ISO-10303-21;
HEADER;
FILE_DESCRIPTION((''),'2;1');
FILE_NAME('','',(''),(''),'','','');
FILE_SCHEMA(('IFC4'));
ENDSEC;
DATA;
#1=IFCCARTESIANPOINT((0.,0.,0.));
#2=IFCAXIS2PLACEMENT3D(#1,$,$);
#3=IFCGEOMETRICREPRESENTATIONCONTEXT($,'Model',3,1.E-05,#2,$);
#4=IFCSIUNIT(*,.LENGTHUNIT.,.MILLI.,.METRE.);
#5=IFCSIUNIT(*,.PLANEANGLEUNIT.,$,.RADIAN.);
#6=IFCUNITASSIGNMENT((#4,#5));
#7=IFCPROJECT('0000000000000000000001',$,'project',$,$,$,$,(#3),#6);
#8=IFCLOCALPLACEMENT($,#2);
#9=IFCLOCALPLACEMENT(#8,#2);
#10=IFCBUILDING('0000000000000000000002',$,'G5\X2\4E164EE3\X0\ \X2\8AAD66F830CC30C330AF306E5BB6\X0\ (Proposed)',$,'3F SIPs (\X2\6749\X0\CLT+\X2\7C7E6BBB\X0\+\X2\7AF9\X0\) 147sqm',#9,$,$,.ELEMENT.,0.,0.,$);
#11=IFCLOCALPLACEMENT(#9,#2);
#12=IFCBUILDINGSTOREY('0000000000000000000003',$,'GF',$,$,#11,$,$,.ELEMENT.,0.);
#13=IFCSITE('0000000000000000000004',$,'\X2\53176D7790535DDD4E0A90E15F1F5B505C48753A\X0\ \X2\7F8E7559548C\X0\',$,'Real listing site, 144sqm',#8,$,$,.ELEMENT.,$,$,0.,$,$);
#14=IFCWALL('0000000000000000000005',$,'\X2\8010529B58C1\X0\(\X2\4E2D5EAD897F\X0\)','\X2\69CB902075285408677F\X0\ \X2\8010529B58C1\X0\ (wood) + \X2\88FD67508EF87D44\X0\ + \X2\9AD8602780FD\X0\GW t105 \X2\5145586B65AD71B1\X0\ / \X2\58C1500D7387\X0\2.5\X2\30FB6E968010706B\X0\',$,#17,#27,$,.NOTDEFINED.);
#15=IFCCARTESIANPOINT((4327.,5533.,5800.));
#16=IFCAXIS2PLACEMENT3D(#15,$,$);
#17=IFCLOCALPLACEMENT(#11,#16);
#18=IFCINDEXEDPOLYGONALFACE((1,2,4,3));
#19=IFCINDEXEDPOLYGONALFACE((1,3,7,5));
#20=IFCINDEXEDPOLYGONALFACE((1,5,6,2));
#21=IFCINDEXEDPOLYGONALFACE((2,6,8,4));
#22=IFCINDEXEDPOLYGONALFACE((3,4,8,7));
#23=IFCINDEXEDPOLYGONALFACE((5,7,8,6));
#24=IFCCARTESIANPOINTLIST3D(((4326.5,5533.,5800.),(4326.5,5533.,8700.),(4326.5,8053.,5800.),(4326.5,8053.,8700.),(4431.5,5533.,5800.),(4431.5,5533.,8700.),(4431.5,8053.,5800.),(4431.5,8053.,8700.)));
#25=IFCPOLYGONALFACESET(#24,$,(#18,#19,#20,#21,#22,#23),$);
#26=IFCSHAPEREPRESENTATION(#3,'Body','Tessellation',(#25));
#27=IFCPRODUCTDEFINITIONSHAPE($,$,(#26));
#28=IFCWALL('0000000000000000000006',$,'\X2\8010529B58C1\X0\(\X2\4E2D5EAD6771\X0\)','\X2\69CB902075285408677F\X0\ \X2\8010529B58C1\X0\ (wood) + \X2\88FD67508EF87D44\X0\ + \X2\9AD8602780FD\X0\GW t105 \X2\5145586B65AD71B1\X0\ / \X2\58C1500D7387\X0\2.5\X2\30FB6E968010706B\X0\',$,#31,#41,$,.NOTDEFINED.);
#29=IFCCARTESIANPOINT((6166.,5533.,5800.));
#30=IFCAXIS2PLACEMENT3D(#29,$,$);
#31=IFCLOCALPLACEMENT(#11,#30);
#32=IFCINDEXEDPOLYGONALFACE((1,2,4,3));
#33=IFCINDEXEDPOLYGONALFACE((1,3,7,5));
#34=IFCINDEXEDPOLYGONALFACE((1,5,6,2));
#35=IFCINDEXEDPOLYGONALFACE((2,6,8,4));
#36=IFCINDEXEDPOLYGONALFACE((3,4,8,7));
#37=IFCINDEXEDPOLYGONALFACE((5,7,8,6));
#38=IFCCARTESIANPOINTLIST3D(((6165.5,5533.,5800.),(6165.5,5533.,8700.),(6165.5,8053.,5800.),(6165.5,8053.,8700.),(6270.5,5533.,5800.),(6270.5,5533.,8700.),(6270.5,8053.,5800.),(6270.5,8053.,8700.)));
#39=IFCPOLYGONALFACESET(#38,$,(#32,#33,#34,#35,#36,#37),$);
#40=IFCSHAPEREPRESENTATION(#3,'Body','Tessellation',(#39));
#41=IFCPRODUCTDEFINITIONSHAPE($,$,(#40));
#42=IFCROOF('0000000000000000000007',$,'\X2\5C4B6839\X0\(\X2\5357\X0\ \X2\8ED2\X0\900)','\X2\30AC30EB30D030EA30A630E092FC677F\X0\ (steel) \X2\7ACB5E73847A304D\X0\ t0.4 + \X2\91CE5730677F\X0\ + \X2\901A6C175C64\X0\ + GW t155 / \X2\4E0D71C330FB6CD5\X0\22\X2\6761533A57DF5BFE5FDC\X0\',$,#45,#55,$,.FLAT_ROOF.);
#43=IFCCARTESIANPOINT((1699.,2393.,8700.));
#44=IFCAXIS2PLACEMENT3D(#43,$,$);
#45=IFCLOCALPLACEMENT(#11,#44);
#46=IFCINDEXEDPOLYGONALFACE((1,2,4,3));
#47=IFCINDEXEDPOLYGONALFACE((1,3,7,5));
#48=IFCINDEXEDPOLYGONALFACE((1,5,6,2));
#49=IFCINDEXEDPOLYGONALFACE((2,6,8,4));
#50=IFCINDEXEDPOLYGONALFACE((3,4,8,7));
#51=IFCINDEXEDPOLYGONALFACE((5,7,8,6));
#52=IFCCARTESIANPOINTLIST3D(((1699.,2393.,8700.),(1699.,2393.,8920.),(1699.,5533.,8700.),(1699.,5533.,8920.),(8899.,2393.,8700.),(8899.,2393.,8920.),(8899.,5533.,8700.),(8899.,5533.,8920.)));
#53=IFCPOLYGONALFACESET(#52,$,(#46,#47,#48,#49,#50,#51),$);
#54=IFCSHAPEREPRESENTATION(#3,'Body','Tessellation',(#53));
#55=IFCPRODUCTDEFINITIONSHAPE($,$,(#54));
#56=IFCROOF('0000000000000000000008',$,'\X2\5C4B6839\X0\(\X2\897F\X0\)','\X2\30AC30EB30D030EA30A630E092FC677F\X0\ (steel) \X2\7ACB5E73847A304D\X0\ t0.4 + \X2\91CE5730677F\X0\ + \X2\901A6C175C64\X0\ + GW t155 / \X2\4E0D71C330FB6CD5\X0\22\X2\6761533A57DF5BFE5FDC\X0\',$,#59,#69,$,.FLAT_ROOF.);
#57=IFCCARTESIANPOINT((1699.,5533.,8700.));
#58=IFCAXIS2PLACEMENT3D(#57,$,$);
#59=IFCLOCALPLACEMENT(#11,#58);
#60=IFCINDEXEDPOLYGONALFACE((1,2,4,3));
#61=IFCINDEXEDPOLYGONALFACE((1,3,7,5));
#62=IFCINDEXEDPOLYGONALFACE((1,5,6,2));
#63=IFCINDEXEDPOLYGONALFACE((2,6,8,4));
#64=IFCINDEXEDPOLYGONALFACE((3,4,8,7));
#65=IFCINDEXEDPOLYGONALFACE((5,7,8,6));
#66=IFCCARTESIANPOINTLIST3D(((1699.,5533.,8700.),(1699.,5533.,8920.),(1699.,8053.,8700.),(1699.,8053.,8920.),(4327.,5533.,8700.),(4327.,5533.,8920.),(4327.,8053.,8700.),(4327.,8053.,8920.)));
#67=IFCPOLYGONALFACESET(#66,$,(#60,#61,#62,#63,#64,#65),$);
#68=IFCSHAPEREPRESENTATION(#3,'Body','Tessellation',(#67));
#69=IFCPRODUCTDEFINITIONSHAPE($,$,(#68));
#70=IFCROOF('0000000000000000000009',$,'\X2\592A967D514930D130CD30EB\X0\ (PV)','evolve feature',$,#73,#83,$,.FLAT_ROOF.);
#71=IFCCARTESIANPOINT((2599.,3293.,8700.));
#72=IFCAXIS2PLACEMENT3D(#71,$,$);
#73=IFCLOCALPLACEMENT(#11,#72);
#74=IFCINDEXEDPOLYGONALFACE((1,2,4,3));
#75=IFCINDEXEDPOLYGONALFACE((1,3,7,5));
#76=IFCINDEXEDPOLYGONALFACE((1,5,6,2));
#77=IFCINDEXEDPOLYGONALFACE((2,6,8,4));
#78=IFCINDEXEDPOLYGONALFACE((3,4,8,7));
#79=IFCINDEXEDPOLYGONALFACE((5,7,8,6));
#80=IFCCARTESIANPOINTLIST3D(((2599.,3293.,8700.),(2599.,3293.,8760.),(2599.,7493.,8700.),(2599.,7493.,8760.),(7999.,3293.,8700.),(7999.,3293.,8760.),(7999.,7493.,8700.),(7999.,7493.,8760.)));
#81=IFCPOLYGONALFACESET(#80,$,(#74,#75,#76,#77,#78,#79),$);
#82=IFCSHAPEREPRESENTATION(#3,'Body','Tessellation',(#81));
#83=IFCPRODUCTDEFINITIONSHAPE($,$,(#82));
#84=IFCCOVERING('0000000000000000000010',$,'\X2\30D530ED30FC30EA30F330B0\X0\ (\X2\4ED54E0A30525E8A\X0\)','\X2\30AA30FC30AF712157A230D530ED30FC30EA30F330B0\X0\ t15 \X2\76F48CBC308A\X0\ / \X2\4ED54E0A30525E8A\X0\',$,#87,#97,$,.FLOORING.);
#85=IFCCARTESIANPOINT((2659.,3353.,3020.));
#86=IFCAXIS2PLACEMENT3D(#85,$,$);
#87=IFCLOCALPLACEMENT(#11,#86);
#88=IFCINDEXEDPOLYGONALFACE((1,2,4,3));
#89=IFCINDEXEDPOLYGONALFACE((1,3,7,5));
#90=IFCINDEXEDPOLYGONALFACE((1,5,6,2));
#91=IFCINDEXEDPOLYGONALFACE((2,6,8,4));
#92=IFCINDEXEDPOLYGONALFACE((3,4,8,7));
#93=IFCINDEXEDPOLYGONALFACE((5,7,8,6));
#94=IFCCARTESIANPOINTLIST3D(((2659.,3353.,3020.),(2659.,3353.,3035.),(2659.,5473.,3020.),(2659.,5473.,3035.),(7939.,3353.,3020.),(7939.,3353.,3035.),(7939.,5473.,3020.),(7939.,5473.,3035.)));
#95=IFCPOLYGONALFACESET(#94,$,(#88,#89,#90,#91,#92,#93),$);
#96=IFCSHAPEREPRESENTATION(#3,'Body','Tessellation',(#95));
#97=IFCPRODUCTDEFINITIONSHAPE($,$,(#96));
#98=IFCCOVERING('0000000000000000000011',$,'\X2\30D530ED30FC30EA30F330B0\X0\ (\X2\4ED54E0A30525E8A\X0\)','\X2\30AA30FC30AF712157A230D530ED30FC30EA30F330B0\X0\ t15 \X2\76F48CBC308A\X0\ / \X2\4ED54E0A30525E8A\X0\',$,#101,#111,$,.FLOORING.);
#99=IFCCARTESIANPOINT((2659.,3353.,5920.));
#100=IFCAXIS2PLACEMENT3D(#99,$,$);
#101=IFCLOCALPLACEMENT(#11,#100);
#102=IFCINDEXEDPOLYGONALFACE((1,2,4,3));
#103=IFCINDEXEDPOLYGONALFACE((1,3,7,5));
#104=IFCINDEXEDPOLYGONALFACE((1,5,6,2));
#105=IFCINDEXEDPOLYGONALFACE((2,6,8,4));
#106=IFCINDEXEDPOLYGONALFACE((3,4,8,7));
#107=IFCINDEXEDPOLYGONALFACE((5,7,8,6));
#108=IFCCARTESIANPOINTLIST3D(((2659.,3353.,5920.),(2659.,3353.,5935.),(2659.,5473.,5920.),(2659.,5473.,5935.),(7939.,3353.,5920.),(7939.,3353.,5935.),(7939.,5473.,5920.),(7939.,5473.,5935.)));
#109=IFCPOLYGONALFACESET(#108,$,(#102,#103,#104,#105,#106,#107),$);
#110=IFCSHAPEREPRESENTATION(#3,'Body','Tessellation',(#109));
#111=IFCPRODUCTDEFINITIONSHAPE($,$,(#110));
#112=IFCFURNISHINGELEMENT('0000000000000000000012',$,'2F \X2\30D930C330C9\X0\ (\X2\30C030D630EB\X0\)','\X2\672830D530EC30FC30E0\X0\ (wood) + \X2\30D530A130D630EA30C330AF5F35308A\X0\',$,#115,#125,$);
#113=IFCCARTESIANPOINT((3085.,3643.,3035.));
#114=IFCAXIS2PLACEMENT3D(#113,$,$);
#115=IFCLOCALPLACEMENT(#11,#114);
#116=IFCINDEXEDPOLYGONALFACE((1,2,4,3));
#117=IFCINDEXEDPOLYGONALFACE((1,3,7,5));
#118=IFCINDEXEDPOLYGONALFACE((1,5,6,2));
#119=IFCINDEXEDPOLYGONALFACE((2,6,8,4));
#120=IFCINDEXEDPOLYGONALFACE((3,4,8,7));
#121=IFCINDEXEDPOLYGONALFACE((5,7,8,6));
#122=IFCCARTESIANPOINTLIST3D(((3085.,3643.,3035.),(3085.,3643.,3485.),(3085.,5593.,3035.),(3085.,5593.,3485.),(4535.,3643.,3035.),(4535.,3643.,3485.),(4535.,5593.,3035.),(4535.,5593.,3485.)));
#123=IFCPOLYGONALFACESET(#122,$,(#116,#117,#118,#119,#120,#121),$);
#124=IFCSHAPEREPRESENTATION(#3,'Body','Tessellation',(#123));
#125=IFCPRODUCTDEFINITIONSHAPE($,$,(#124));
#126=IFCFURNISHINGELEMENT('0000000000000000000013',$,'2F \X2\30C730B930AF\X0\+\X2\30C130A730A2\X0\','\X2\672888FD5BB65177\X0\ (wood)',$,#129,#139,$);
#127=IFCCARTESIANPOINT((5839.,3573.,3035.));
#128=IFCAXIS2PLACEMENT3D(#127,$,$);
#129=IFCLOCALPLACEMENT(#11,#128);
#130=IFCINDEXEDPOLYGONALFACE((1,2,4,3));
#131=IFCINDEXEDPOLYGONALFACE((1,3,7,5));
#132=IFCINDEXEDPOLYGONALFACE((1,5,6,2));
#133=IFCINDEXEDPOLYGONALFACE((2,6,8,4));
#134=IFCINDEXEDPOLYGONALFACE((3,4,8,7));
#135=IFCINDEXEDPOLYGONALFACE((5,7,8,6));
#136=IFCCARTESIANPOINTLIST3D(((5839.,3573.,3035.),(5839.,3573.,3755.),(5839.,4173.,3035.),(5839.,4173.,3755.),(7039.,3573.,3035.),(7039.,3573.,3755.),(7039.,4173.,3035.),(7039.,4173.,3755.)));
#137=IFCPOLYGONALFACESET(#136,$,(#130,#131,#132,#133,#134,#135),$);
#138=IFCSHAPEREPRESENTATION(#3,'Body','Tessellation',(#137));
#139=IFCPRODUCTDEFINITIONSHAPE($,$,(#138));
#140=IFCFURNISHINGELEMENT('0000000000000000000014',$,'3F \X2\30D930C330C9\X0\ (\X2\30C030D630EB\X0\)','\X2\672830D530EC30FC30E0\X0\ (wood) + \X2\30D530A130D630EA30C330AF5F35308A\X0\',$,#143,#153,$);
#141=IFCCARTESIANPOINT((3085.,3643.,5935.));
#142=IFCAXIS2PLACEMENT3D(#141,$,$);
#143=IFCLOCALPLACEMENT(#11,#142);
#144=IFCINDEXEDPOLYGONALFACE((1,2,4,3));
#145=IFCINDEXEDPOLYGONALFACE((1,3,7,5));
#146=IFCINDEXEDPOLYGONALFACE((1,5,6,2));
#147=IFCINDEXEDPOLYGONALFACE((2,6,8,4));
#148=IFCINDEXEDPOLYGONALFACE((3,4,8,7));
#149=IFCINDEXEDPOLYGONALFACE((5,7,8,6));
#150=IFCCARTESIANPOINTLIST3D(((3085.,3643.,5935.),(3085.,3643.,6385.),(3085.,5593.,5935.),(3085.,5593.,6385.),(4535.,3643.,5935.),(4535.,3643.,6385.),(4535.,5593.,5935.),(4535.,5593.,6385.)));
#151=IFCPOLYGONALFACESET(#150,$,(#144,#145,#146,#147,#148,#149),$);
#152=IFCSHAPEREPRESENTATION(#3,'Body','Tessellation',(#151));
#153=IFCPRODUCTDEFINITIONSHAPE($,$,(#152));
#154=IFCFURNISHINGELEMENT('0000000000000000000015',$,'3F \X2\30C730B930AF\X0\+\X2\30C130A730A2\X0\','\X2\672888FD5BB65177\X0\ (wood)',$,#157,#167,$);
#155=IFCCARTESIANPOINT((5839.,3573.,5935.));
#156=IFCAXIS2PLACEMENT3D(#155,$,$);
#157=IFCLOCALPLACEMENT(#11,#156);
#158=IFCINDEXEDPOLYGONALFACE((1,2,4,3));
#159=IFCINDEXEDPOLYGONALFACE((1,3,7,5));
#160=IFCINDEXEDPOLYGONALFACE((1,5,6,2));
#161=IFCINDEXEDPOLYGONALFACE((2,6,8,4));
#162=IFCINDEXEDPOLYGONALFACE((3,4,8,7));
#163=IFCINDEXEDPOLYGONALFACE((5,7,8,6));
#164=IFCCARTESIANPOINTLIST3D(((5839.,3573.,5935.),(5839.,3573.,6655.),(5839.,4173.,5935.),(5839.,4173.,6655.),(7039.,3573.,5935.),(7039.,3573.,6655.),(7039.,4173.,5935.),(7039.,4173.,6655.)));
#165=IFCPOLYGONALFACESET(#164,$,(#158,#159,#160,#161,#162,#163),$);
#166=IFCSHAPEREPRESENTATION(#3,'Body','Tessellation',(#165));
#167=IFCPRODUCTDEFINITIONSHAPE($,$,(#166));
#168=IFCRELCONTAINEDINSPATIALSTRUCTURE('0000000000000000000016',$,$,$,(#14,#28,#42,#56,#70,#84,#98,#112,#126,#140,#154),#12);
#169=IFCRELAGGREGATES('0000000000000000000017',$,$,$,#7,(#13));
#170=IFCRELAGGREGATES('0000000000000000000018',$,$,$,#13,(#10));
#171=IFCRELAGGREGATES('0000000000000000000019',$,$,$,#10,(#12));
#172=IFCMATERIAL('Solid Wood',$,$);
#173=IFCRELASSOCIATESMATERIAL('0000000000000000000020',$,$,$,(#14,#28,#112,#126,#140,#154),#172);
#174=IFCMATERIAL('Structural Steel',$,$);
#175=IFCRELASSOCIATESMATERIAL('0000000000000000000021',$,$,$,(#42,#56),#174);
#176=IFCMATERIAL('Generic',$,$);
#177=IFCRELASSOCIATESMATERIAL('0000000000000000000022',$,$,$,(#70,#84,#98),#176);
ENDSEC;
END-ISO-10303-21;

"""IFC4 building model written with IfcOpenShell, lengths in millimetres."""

from ifc_helpers import new_model, si_unit, frame, frame_2d, origin, place, context, project, spatial, rectangle, extrude, material, element, save


model = new_model("IFC4")

# Units and contexts
model_context = context("Model", 3, precision=1e-05, world=origin())
ifc_project = project(units=[si_unit("LENGTHUNIT", "METRE", prefix="MILLI"), si_unit("PLANEANGLEUNIT", "RADIAN")], contexts=[model_context])

# Site, building, storey
site_placement = place(None, origin())
site = spatial("IfcSite", under=ifc_project, at=site_placement, Name="北海道川上郡弟子屈町 美留和", ObjectType="Real listing site, 144sqm", CompositionType="ELEMENT", RefElevation=0.0)
building_placement = place(site_placement, origin())
building = spatial("IfcBuilding", under=site, at=building_placement, Name="G5世代 読書ヌックの家 (Proposed)", ObjectType="3F SIPs (杉CLT+籾殻+竹) 147sqm", CompositionType="ELEMENT", ElevationOfRefHeight=0.0, ElevationOfTerrain=0.0)
storey_placement = place(building_placement, origin())
storey = spatial("IfcBuildingStorey", under=building, at=storey_placement, Name="GF", CompositionType="ELEMENT", Elevation=0.0)

# Shared definitions
ifc_material_1 = material(Name="Solid Wood")

# Walls
wall_1_placement = place(storey_placement, frame((4327.0, 5533.0, 5800.0)))
element("IfcWall", 1, at=wall_1_placement, inside=storey, material=ifc_material_1, Name="耐力壁(中庭西)", Description="構造用合板 耐力壁 (wood) + 製材軸組 + 高性能GW t105 充填断熱 / 壁倍率2.5・準耐火", PredefinedType="NOTDEFINED", context=model_context, shape_type="SweptSolid", body=[
    extrude(rectangle(XDim=105.0, YDim=2520.0, at=frame_2d((52.0, 1260.0))), frame((4327.0, 5533.0, 5800.0)), (0.0, 0.0, 1.0), 2900.0),
])
wall_2_placement = place(storey_placement, frame((6166.0, 5533.0, 5800.0)))
element("IfcWall", 2, at=wall_2_placement, inside=storey, material=ifc_material_1, Name="耐力壁(中庭東)", Description="構造用合板 耐力壁 (wood) + 製材軸組 + 高性能GW t105 充填断熱 / 壁倍率2.5・準耐火", PredefinedType="NOTDEFINED", context=model_context, shape_type="SweptSolid", body=[
    extrude(rectangle(XDim=105.0, YDim=2520.0, at=frame_2d((52.0, 1260.0))), frame((6166.0, 5533.0, 5800.0)), (0.0, 0.0, 1.0), 2900.0),
])

# Roofs
ifc_material_2 = material(Name="Structural Steel")
roof_1_placement = place(storey_placement, frame((1699.0, 2393.0, 8700.0)))
element("IfcRoof", 3, at=roof_1_placement, inside=storey, material=ifc_material_2, Name="屋根(南 軒900)", Description="ガルバリウム鋼板 (steel) 立平葺き t0.4 + 野地板 + 通気層 + GW t155 / 不燃・法22条区域対応", PredefinedType="FLAT_ROOF", context=model_context, shape_type="SweptSolid", body=[
    extrude(rectangle(XDim=7200.0, YDim=3140.0, at=frame_2d((3600.0, 1570.0))), frame((1699.0, 2393.0, 8700.0)), (0.0, 0.0, 1.0), 220.0),
])
roof_2_placement = place(storey_placement, frame((1699.0, 5533.0, 8700.0)))
element("IfcRoof", 4, at=roof_2_placement, inside=storey, material=ifc_material_2, Name="屋根(西)", Description="ガルバリウム鋼板 (steel) 立平葺き t0.4 + 野地板 + 通気層 + GW t155 / 不燃・法22条区域対応", PredefinedType="FLAT_ROOF", context=model_context, shape_type="SweptSolid", body=[
    extrude(rectangle(XDim=2628.0, YDim=2520.0, at=frame_2d((1314.0, 1260.0))), frame((1699.0, 5533.0, 8700.0)), (0.0, 0.0, 1.0), 220.0),
])
ifc_material_3 = material(Name="Generic")
roof_3_placement = place(storey_placement, frame((2599.0, 3293.0, 8700.0)))
element("IfcRoof", 5, at=roof_3_placement, inside=storey, material=ifc_material_3, Name="太陽光パネル (PV)", Description="evolve feature", PredefinedType="FLAT_ROOF", context=model_context, shape_type="SweptSolid", body=[
    extrude(rectangle(XDim=5400.0, YDim=4200.0, at=frame_2d((2700.0, 2100.0))), frame((2599.0, 3293.0, 8700.0)), (0.0, 0.0, 1.0), 60.0),
])

# Coverings
covering_1_placement = place(storey_placement, frame((2659.0, 3353.0, 3020.0)))
element("IfcCovering", 6, at=covering_1_placement, inside=storey, material=ifc_material_3, Name="フローリング (仕上げ床)", Description="オーク無垢フローリング t15 直貼り / 仕上げ床", PredefinedType="FLOORING", context=model_context, shape_type="SweptSolid", body=[
    extrude(rectangle(XDim=5280.0, YDim=2120.0, at=frame_2d((2640.0, 1060.0))), frame((2659.0, 3353.0, 3020.0)), (0.0, 0.0, 1.0), 15.0),
])
covering_2_placement = place(storey_placement, frame((2659.0, 3353.0, 5920.0)))
element("IfcCovering", 7, at=covering_2_placement, inside=storey, material=ifc_material_3, Name="フローリング (仕上げ床)", Description="オーク無垢フローリング t15 直貼り / 仕上げ床", PredefinedType="FLOORING", context=model_context, shape_type="SweptSolid", body=[
    extrude(rectangle(XDim=5280.0, YDim=2120.0, at=frame_2d((2640.0, 1060.0))), frame((2659.0, 3353.0, 5920.0)), (0.0, 0.0, 1.0), 15.0),
])

# Furnishing elements
furnishing_1_placement = place(storey_placement, frame((3085.0, 3643.0, 3035.0)))
element("IfcFurnishingElement", 8, at=furnishing_1_placement, inside=storey, material=ifc_material_1, Name="2F ベッド (ダブル)", Description="木フレーム (wood) + ファブリック張り", context=model_context, shape_type="SweptSolid", body=[
    extrude(rectangle(XDim=1450.0, YDim=1950.0, at=frame_2d((725.0, 975.0))), frame((3085.0, 3643.0, 3035.0)), (0.0, 0.0, 1.0), 450.0),
])
furnishing_2_placement = place(storey_placement, frame((5839.0, 3573.0, 3035.0)))
element("IfcFurnishingElement", 9, at=furnishing_2_placement, inside=storey, material=ifc_material_1, Name="2F デスク+チェア", Description="木製家具 (wood)", context=model_context, shape_type="SweptSolid", body=[
    extrude(rectangle(XDim=1200.0, YDim=600.0, at=frame_2d((600.0, 300.0))), frame((5839.0, 3573.0, 3035.0)), (0.0, 0.0, 1.0), 720.0),
])
furnishing_3_placement = place(storey_placement, frame((3085.0, 3643.0, 5935.0)))
element("IfcFurnishingElement", 10, at=furnishing_3_placement, inside=storey, material=ifc_material_1, Name="3F ベッド (ダブル)", Description="木フレーム (wood) + ファブリック張り", context=model_context, shape_type="SweptSolid", body=[
    extrude(rectangle(XDim=1450.0, YDim=1950.0, at=frame_2d((725.0, 975.0))), frame((3085.0, 3643.0, 5935.0)), (0.0, 0.0, 1.0), 450.0),
])
furnishing_4_placement = place(storey_placement, frame((5839.0, 3573.0, 5935.0)))
element("IfcFurnishingElement", 11, at=furnishing_4_placement, inside=storey, material=ifc_material_1, Name="3F デスク+チェア", Description="木製家具 (wood)", context=model_context, shape_type="SweptSolid", body=[
    extrude(rectangle(XDim=1200.0, YDim=600.0, at=frame_2d((600.0, 300.0))), frame((5839.0, 3573.0, 5935.0)), (0.0, 0.0, 1.0), 720.0),
])

save(model, "model.ifc")
